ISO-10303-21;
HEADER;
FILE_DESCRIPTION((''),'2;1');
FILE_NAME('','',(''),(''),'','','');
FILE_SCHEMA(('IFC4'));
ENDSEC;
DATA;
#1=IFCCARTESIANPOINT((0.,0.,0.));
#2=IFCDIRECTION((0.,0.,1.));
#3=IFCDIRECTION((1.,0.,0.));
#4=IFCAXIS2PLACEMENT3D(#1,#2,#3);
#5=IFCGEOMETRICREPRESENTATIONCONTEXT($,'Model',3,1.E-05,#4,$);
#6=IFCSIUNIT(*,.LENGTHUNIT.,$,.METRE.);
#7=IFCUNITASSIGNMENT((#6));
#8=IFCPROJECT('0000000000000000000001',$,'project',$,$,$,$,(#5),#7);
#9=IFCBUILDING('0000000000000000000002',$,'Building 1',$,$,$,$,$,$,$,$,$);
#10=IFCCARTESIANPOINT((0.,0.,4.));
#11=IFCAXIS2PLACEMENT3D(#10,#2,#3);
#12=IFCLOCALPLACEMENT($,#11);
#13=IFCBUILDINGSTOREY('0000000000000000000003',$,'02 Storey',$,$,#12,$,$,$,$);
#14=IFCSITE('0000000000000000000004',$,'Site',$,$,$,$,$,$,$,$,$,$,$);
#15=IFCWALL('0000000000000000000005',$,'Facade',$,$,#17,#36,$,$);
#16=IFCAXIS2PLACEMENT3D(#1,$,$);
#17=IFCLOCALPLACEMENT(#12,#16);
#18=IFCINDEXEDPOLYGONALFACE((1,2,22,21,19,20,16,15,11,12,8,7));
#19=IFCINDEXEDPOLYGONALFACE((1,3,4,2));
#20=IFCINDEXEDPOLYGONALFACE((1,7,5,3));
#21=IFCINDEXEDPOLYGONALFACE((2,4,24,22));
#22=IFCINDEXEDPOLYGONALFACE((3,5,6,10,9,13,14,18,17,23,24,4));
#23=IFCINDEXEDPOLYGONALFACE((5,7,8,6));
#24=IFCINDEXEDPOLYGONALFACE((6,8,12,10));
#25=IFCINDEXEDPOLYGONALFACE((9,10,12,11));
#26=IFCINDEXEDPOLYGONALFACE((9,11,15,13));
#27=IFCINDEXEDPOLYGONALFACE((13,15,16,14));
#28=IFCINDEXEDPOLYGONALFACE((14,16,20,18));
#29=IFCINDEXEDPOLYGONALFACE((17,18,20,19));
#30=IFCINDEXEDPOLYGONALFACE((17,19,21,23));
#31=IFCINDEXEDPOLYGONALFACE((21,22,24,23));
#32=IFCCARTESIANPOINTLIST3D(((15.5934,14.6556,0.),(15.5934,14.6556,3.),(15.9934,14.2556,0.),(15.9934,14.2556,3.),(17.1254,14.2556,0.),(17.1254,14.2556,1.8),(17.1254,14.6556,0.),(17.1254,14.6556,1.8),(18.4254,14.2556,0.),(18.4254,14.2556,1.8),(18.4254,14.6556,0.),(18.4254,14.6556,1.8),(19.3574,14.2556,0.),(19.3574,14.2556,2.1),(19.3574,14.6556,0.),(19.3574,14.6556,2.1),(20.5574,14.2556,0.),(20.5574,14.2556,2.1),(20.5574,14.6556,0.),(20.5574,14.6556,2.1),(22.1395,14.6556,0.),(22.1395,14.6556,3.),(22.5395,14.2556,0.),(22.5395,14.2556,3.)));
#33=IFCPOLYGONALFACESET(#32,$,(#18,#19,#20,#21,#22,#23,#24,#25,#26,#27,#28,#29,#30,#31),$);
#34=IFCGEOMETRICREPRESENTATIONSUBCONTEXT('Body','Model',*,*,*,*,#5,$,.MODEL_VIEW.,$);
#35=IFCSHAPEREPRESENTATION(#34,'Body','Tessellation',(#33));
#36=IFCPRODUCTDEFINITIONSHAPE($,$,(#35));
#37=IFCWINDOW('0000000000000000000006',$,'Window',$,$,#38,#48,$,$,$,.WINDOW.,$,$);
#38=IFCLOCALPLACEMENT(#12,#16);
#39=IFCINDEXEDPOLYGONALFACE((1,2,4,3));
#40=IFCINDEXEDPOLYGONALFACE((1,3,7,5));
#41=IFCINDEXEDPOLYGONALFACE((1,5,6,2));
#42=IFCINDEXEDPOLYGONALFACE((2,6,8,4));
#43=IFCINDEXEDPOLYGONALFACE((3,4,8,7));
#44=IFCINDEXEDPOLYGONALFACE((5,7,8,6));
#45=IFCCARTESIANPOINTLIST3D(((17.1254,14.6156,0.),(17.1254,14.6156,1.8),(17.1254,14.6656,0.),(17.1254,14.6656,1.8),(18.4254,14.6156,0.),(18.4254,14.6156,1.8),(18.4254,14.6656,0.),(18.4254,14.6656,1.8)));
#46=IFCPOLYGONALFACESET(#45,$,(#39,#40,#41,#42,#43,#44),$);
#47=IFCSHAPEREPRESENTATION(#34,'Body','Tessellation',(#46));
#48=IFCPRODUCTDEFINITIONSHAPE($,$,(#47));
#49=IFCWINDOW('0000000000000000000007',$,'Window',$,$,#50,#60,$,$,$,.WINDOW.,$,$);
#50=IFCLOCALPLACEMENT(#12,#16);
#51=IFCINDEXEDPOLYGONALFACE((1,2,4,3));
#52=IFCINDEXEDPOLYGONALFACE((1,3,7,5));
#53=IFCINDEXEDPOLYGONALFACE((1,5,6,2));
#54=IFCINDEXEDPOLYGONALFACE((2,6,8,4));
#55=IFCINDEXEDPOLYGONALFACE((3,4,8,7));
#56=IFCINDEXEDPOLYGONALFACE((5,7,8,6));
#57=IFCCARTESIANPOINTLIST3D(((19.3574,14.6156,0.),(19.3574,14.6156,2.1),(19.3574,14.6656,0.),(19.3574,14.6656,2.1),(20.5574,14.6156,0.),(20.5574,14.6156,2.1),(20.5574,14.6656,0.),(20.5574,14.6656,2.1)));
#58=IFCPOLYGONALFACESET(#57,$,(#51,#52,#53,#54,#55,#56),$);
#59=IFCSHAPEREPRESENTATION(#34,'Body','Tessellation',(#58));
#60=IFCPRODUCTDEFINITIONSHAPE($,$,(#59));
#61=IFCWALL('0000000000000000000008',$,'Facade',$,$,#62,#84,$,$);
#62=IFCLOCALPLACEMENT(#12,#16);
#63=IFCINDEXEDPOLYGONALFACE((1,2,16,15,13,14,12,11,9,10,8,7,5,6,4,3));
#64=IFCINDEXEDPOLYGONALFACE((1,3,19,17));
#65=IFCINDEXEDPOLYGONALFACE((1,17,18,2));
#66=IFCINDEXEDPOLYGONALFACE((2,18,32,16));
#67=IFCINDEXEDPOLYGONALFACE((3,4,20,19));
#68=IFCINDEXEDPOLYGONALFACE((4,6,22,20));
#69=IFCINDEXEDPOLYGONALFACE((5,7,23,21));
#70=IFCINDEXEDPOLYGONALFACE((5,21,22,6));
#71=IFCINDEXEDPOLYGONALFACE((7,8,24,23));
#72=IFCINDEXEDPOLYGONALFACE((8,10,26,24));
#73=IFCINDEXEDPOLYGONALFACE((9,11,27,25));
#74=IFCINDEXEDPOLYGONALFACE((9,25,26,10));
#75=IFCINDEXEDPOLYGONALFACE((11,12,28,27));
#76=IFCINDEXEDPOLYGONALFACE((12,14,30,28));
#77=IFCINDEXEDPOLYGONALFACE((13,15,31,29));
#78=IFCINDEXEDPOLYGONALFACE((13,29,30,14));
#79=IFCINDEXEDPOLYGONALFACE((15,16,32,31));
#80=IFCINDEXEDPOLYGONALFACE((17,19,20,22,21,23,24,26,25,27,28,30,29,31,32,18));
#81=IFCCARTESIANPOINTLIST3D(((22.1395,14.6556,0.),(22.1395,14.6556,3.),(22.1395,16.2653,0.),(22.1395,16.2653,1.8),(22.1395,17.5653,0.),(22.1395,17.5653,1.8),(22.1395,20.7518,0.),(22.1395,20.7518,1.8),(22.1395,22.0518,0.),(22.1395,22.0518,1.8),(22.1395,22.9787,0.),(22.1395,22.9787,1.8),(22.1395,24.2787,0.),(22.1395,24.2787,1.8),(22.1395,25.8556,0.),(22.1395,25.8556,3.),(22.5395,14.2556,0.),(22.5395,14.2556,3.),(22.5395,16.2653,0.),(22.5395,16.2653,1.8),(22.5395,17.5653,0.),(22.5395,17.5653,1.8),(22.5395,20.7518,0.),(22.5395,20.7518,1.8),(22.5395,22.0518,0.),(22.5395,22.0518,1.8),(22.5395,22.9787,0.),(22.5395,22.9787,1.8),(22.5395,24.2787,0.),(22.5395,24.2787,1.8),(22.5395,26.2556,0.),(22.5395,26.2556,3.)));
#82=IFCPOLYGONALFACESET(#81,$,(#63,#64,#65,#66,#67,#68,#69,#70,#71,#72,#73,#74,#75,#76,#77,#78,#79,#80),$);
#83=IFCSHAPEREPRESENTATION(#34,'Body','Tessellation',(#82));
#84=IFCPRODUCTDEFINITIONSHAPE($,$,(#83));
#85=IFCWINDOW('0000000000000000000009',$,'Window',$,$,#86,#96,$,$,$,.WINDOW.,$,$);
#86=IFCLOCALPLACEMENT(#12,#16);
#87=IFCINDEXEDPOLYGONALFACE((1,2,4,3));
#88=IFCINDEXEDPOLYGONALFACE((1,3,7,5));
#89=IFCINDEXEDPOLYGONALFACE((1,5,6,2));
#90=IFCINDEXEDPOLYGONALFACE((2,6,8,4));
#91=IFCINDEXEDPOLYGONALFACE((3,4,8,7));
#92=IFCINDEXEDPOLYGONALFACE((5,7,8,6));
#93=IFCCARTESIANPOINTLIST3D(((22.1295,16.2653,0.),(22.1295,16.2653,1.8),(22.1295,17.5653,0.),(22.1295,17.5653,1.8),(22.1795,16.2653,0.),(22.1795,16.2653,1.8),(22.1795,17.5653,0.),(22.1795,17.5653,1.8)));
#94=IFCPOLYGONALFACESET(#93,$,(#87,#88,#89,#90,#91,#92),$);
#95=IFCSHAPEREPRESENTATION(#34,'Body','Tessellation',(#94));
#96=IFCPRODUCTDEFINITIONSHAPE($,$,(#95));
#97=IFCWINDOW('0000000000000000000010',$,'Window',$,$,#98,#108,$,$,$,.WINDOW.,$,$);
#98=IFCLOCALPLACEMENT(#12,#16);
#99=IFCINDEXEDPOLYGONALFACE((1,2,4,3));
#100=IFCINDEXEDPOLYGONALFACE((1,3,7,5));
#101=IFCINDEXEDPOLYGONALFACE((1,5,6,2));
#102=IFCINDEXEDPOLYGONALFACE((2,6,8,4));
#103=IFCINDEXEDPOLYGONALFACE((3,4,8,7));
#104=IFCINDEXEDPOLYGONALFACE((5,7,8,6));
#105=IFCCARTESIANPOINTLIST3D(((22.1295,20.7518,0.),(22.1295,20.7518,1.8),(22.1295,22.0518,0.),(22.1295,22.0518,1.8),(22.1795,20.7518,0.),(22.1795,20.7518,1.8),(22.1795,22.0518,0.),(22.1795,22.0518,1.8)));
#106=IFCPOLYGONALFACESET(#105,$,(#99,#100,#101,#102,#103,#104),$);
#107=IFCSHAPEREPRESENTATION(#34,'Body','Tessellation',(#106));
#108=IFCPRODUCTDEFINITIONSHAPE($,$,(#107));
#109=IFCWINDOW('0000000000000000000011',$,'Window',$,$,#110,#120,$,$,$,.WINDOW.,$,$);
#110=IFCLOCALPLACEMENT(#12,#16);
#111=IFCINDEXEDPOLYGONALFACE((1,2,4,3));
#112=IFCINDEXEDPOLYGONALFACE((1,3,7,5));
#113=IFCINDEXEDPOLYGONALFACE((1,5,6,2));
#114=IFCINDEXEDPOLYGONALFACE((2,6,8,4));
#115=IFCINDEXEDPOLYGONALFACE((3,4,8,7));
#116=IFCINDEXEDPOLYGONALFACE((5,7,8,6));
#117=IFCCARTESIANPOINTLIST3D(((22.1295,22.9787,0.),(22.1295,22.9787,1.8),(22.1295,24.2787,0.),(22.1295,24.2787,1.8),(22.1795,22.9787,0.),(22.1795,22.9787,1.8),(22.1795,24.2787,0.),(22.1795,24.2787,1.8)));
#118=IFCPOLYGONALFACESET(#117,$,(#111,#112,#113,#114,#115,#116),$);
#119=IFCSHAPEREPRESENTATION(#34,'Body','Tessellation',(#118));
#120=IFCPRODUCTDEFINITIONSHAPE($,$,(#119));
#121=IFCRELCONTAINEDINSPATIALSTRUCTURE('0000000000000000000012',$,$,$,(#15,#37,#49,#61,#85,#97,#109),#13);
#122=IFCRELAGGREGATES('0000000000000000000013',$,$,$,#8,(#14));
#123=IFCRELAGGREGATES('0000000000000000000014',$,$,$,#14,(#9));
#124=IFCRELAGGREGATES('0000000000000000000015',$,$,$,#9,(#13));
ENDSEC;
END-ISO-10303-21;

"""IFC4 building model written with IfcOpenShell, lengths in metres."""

from ifc_helpers import new_model, si_unit, frame, origin_with_axes, place, context, subcontext, project, spatial, line, indexed_curve, outline, extrude, element, fill, save


model = new_model("IFC4")

# Units and contexts
model_context = context("Model", 3, precision=1e-05, world=origin_with_axes())
body_context = subcontext(model_context, "Body", "Model", "MODEL_VIEW")
ifc_project = project(units=[si_unit("LENGTHUNIT", "METRE")], contexts=[model_context])

# Site, building, storey
site = spatial("IfcSite", under=ifc_project, Name="Site")
building = spatial("IfcBuilding", under=site, Name="Building 1")
storey_placement = place(None, frame((0.0, 0.0, 4.0), z_axis=(0.0, 0.0, 1.0), x_axis=(1.0, 0.0, 0.0)))
storey = spatial("IfcBuildingStorey", under=building, at=storey_placement, Name="02 Storey")

# Walls, openings, windows
wall_1_placement = place(storey_placement, origin_with_axes())
wall_1 = element("IfcWall", 1, at=wall_1_placement, inside=storey, Name="Facade", context=body_context, shape_type="SweptSolid", body=[
    extrude(outline(indexed_curve([(15.5934, 14.6556), (22.1395, 14.6556), (22.5395, 14.2556), (15.9934, 14.2556)], segments=[line(1, 2), line(2, 3), line(3, 4)])), origin_with_axes(), (0.0, 0.0, 1.0), 3.0),
])
opening_1_placement = place(wall_1_placement, origin_with_axes())
opening_1 = element("IfcOpeningElement", 2, at=opening_1_placement, cuts=wall_1, context=body_context, shape_type="SweptSolid", body=[
    extrude(outline(indexed_curve([(17.1254, 14.2156), (17.1254, 14.7156), (18.4254, 14.7156), (18.4254, 14.2156)], segments=[line(1, 2), line(2, 3), line(3, 4)])), origin_with_axes(), (0.0, 0.0, 1.0), 1.8),
])
opening_2_placement = place(wall_1_placement, origin_with_axes())
opening_2 = element("IfcOpeningElement", 3, at=opening_2_placement, cuts=wall_1, context=body_context, shape_type="SweptSolid", body=[
    extrude(outline(indexed_curve([(19.3574, 14.2156), (19.3574, 14.7156), (20.5574, 14.7156), (20.5574, 14.2156)], segments=[line(1, 2), line(2, 3), line(3, 4)])), origin_with_axes(), (0.0, 0.0, 1.0), 2.1),
])
window_1_placement = place(storey_placement, origin_with_axes())
window_1 = element("IfcWindow", 4, at=window_1_placement, inside=storey, Name="Window", PredefinedType="WINDOW", context=body_context, shape_type="SweptSolid", body=[
    extrude(outline(indexed_curve([(17.1254, 14.6156), (17.1254, 14.6656), (18.4254, 14.6656), (18.4254, 14.6156)], segments=[line(1, 2), line(2, 3), line(3, 4)])), origin_with_axes(), (0.0, 0.0, 1.0), 1.8),
])
fill(opening_1, window_1)
window_2_placement = place(storey_placement, origin_with_axes())
window_2 = element("IfcWindow", 5, at=window_2_placement, inside=storey, Name="Window", PredefinedType="WINDOW", context=body_context, shape_type="SweptSolid", body=[
    extrude(outline(indexed_curve([(19.3574, 14.6156), (19.3574, 14.6656), (20.5574, 14.6656), (20.5574, 14.6156)], segments=[line(1, 2), line(2, 3), line(3, 4)])), origin_with_axes(), (0.0, 0.0, 1.0), 2.1),
])
fill(opening_2, window_2)
wall_2_placement = place(storey_placement, origin_with_axes())
wall_2 = element("IfcWall", 6, at=wall_2_placement, inside=storey, Name="Facade", context=body_context, shape_type="SweptSolid", body=[
    extrude(outline(indexed_curve([(22.1395, 14.6556), (22.1395, 25.8556), (22.5395, 26.2556), (22.5395, 14.2556)], segments=[line(1, 2), line(2, 3), line(3, 4)])), origin_with_axes(), (0.0, 0.0, 1.0), 3.0),
])
opening_3_placement = place(wall_2_placement, origin_with_axes())
opening_3 = element("IfcOpeningElement", 7, at=opening_3_placement, cuts=wall_2, context=body_context, shape_type="SweptSolid", body=[
    extrude(outline(indexed_curve([(22.5795, 16.2653), (22.0795, 16.2653), (22.0795, 17.5653), (22.5795, 17.5653)], segments=[line(1, 2), line(2, 3), line(3, 4)])), origin_with_axes(), (0.0, 0.0, 1.0), 1.8),
])
opening_4_placement = place(wall_2_placement, origin_with_axes())
opening_4 = element("IfcOpeningElement", 8, at=opening_4_placement, cuts=wall_2, context=body_context, shape_type="SweptSolid", body=[
    extrude(outline(indexed_curve([(22.5795, 20.7518), (22.0795, 20.7518), (22.0795, 22.0518), (22.5795, 22.0518)], segments=[line(1, 2), line(2, 3), line(3, 4)])), origin_with_axes(), (0.0, 0.0, 1.0), 1.8),
])
opening_5_placement = place(wall_2_placement, origin_with_axes())
opening_5 = element("IfcOpeningElement", 9, at=opening_5_placement, cuts=wall_2, context=body_context, shape_type="SweptSolid", body=[
    extrude(outline(indexed_curve([(22.5795, 22.9787), (22.0795, 22.9787), (22.0795, 24.2787), (22.5795, 24.2787)], segments=[line(1, 2), line(2, 3), line(3, 4)])), origin_with_axes(), (0.0, 0.0, 1.0), 1.8),
])
window_3_placement = place(storey_placement, origin_with_axes())
window_3 = element("IfcWindow", 10, at=window_3_placement, inside=storey, Name="Window", PredefinedType="WINDOW", context=body_context, shape_type="SweptSolid", body=[
    extrude(outline(indexed_curve([(22.1795, 16.2653), (22.1295, 16.2653), (22.1295, 17.5653), (22.1795, 17.5653)], segments=[line(1, 2), line(2, 3), line(3, 4)])), origin_with_axes(), (0.0, 0.0, 1.0), 1.8),
])
fill(opening_3, window_3)
window_4_placement = place(storey_placement, origin_with_axes())
window_4 = element("IfcWindow", 11, at=window_4_placement, inside=storey, Name="Window", PredefinedType="WINDOW", context=body_context, shape_type="SweptSolid", body=[
    extrude(outline(indexed_curve([(22.1795, 20.7518), (22.1295, 20.7518), (22.1295, 22.0518), (22.1795, 22.0518)], segments=[line(1, 2), line(2, 3), line(3, 4)])), origin_with_axes(), (0.0, 0.0, 1.0), 1.8),
])
fill(opening_4, window_4)
window_5_placement = place(storey_placement, origin_with_axes())
window_5 = element("IfcWindow", 12, at=window_5_placement, inside=storey, Name="Window", PredefinedType="WINDOW", context=body_context, shape_type="SweptSolid", body=[
    extrude(outline(indexed_curve([(22.1795, 22.9787), (22.1295, 22.9787), (22.1295, 24.2787), (22.1795, 24.2787)], segments=[line(1, 2), line(2, 3), line(3, 4)])), origin_with_axes(), (0.0, 0.0, 1.0), 1.8),
])
fill(opening_5, window_5)

save(model, "model.ifc")
